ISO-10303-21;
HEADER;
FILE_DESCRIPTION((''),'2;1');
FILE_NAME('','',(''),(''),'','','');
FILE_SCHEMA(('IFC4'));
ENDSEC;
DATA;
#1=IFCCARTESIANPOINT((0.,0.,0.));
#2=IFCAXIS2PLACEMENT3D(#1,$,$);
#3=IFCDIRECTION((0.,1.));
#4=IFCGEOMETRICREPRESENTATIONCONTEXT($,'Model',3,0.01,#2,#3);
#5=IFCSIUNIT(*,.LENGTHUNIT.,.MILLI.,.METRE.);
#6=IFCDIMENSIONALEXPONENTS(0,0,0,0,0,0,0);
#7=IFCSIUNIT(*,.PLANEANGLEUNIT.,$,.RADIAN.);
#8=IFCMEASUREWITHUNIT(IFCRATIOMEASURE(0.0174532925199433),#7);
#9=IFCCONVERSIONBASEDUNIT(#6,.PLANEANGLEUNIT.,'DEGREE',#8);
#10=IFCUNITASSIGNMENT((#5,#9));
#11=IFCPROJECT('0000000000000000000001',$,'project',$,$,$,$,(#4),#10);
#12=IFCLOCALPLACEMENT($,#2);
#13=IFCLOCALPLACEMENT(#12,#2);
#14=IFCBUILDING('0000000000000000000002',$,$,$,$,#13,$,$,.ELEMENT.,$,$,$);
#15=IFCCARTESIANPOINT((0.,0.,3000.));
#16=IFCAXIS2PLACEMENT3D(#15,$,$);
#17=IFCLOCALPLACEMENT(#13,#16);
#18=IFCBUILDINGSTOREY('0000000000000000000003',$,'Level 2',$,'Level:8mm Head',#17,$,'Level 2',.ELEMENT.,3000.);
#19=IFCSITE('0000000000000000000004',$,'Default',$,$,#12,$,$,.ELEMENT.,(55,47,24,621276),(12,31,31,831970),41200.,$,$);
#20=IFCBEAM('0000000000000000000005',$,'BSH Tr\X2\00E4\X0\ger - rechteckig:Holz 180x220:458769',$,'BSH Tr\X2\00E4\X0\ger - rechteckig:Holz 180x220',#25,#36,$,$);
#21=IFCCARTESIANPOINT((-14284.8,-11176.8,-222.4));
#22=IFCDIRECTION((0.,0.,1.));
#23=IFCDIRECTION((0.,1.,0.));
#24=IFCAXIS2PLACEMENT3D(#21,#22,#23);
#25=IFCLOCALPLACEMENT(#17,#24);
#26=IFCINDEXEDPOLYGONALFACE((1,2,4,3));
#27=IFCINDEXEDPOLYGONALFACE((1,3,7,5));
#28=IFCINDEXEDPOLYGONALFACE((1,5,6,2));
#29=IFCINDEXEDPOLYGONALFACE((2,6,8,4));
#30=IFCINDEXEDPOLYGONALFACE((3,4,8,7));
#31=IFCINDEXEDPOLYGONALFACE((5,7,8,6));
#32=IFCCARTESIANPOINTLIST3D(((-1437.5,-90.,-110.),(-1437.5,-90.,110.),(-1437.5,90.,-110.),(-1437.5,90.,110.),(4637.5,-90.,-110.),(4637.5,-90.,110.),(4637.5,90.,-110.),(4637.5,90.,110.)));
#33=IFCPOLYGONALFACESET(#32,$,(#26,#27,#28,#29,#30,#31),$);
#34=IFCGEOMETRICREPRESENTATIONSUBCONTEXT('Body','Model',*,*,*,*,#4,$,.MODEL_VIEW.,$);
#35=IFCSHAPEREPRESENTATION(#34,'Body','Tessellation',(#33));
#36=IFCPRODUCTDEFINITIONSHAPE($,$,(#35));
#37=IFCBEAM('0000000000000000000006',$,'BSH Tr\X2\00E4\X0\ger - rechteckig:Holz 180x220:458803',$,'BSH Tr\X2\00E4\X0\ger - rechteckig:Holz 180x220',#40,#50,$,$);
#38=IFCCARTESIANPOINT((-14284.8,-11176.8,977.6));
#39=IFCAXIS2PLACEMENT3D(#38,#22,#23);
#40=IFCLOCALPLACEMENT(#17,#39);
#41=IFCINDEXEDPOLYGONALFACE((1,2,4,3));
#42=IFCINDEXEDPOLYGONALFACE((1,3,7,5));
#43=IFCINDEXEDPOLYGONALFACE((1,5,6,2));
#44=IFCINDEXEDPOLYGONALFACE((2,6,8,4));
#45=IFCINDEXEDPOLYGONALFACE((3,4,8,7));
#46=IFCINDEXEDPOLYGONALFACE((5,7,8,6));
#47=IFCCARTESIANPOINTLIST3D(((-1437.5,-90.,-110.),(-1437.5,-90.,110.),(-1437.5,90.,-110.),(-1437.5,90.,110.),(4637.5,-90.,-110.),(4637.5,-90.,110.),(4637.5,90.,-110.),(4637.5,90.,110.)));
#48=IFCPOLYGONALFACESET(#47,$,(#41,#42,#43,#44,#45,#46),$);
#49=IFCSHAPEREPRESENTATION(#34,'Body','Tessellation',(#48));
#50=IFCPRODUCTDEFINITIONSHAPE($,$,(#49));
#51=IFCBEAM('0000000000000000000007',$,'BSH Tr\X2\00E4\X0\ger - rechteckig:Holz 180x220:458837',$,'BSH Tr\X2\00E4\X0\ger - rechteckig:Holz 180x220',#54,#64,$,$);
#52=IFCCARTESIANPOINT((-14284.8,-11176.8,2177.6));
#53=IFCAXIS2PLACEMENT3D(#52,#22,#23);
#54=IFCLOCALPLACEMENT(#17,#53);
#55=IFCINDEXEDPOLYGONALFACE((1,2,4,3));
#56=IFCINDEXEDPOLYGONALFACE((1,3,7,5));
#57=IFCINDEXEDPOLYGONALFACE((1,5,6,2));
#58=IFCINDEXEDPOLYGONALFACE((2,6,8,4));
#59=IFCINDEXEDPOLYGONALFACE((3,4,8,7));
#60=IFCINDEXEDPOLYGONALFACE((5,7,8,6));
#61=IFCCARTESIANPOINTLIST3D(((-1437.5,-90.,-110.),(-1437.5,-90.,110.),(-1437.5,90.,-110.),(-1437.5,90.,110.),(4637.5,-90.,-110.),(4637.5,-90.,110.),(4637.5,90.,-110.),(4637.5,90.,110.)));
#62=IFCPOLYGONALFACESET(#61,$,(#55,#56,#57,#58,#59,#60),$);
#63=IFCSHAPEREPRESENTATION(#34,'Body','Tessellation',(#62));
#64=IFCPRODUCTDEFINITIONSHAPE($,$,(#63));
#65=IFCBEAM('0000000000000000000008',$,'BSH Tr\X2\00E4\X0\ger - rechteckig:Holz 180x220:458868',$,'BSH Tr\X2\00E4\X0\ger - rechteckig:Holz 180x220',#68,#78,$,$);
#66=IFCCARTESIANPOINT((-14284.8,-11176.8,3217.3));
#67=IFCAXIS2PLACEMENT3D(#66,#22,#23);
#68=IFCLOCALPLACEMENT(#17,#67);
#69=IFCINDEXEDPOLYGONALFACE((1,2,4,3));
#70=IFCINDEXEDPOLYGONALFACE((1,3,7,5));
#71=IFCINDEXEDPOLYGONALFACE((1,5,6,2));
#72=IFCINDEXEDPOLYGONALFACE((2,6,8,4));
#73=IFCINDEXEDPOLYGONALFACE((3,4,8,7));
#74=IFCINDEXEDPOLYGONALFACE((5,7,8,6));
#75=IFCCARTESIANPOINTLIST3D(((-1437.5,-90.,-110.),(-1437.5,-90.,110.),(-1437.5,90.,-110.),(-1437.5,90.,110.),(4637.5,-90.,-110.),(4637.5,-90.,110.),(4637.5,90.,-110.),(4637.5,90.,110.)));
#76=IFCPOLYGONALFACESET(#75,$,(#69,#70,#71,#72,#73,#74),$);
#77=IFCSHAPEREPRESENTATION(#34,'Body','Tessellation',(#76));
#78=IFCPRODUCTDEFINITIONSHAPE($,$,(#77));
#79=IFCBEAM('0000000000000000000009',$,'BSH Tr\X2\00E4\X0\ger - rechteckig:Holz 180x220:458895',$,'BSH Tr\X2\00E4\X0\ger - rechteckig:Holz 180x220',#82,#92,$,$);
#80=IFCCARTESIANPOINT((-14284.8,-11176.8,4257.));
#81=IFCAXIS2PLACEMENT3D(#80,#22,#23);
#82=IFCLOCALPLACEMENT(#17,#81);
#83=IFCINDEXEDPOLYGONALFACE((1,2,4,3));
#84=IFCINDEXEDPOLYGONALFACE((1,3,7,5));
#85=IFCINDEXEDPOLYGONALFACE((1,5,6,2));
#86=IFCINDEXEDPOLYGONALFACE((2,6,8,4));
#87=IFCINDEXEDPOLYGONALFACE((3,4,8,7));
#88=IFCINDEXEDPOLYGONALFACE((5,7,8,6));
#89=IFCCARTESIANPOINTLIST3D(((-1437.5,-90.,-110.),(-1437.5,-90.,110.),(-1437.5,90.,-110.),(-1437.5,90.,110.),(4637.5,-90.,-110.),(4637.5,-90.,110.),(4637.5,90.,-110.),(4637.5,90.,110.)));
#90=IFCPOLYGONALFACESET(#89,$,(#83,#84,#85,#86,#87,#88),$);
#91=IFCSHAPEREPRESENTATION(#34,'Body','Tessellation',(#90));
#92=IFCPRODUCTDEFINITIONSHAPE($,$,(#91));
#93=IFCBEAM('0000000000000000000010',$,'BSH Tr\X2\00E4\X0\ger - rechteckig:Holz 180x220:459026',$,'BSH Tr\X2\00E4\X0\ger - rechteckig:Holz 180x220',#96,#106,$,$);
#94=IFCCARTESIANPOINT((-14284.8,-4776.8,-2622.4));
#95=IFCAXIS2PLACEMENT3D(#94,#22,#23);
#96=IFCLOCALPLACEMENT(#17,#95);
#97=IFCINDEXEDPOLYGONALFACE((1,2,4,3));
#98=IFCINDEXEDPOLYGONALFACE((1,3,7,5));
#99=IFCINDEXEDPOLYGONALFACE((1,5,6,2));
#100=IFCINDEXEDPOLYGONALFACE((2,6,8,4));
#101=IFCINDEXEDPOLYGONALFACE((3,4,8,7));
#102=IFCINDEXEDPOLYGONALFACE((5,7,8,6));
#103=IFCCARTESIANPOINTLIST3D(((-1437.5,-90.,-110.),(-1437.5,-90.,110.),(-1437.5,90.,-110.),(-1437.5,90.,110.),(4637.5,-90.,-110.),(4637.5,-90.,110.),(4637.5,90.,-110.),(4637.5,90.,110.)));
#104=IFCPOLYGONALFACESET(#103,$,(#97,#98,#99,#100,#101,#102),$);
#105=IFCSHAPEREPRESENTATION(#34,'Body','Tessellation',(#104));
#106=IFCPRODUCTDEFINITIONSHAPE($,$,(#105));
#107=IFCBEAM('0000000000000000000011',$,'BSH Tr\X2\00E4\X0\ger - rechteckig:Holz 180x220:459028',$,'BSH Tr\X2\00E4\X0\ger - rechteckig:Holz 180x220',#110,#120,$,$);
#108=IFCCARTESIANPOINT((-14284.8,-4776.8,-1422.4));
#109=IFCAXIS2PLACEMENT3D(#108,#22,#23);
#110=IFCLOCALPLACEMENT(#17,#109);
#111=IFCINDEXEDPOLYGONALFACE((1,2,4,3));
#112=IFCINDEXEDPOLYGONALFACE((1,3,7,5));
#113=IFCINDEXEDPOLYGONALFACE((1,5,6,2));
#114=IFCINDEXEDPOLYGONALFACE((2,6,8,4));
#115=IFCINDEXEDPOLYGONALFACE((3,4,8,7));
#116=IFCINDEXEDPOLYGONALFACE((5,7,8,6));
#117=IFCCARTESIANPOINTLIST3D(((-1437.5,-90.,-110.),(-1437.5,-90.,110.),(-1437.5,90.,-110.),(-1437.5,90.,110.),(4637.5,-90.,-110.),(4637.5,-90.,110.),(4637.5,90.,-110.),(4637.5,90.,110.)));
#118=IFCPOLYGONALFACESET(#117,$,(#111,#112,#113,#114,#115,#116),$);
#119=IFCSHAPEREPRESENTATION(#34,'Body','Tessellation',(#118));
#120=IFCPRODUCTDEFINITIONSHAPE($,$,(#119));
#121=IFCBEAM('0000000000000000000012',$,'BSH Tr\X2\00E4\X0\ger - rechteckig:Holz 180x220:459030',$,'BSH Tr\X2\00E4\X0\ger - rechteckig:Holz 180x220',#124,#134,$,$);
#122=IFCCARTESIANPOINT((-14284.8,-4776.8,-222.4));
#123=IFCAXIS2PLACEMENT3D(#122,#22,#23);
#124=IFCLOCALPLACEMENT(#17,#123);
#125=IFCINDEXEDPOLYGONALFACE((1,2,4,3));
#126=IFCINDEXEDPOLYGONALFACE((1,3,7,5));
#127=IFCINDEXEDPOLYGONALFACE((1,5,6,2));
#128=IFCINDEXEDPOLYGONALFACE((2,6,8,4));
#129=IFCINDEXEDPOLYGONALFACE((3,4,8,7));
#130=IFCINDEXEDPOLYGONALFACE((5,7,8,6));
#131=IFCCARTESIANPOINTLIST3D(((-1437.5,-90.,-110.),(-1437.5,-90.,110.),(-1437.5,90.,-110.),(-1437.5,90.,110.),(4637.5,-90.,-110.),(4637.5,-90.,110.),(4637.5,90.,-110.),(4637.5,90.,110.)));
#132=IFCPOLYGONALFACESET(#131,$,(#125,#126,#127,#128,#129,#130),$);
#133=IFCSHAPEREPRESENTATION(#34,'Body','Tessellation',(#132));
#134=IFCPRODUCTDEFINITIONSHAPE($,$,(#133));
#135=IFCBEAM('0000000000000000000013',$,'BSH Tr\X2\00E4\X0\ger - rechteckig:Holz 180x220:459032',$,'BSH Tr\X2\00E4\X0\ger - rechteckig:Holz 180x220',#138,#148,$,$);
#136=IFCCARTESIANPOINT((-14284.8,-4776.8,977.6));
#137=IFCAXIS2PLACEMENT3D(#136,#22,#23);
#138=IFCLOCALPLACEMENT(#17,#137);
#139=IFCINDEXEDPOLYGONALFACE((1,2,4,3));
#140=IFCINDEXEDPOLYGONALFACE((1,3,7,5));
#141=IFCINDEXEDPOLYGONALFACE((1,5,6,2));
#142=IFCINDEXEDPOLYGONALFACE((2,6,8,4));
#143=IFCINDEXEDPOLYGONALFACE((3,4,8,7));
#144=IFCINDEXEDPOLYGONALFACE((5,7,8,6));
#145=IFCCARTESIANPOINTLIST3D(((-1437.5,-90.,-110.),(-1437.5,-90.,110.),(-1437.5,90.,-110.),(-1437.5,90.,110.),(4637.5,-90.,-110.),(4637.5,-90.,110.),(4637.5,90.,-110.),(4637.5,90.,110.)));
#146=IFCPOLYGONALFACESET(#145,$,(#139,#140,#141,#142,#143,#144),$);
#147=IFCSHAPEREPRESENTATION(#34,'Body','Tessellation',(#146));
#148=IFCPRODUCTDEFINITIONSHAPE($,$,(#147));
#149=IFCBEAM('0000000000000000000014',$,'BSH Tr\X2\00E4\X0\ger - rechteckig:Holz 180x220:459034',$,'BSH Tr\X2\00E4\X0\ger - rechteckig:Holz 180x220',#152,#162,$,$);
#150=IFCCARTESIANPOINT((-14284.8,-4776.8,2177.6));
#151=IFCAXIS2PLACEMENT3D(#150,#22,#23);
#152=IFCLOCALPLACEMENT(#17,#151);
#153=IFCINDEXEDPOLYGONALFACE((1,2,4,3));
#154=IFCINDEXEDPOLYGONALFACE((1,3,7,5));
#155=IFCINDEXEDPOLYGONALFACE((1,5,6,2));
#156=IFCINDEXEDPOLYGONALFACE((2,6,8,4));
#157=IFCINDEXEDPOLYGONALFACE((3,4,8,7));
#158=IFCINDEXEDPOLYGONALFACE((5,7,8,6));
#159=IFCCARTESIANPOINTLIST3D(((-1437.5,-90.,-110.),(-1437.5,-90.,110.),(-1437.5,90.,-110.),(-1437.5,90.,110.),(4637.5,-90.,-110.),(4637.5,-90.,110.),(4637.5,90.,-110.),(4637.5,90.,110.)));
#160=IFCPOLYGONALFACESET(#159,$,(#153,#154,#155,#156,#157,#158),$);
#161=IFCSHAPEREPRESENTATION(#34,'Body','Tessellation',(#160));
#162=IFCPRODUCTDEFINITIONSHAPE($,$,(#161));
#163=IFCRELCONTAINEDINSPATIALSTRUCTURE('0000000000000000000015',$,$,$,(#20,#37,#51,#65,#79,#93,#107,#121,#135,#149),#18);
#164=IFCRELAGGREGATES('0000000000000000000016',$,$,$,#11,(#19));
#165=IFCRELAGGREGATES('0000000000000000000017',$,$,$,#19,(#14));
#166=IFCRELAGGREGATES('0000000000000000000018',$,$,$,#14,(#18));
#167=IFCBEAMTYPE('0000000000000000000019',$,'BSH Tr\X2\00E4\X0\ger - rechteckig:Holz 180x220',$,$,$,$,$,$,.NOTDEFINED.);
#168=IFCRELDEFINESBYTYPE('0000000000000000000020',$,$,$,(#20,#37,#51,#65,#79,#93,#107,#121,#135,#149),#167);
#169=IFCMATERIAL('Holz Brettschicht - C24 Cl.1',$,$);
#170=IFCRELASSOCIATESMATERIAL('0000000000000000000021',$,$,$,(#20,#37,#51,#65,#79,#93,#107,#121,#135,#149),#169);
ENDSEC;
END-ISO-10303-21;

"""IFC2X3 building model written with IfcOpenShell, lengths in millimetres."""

from ifc_helpers import new_model, entity, si_unit, converted_unit, direction, frame, frame_2d, origin, place, context, subcontext, project, spatial, rectangle, extrude, material, type_object, element, save


model = new_model("IFC2X3")

# Units and contexts
model_context = context("Model", 3, precision=0.01, world=origin(), true_north=direction((0.0, 1.0)))
body_context = subcontext(model_context, "Body", "Model", "MODEL_VIEW")
ifc_project = project(units=[si_unit("LENGTHUNIT", "METRE", prefix="MILLI"), converted_unit("PLANEANGLEUNIT", "DEGREE", entity("IfcRatioMeasure", 0.0174532925199433), si_unit("PLANEANGLEUNIT", "RADIAN"), dimensions=[0, 0, 0, 0, 0, 0, 0])], contexts=[model_context])

# Site, building, storey
site_placement = place(None, origin())
site = spatial("IfcSite", under=ifc_project, at=site_placement, Name="Default", CompositionType="ELEMENT", RefLatitude=(55, 47, 24, 621276), RefLongitude=(12, 31, 31, 831970), RefElevation=41200.0)
building_placement = place(site_placement, origin())
building = spatial("IfcBuilding", under=site, at=building_placement, CompositionType="ELEMENT")
storey_placement = place(building_placement, frame((0.0, 0.0, 3000.0)))
storey = spatial("IfcBuildingStorey", under=building, at=storey_placement, Name="Level 2", ObjectType="Level:8mm Head", LongName="Level 2", CompositionType="ELEMENT", Elevation=3000.0)

# Beams
ifc_material = material(Name="Holz Brettschicht - C24 Cl.1")
beam_type_1 = type_object("IfcBeamType", Name="BSH Träger - rechteckig:Holz 180x220", PredefinedType="NOTDEFINED")
for number, where, z_axis, x_axis, name in (
    (1, (-14284.8, -11176.8, -222.4), (0.0, 0.0, 1.0), (0.0, 1.0, 0.0), "BSH Träger - rechteckig:Holz 180x220:458769"),
    (2, (-14284.8, -11176.8, 977.6), (0.0, 0.0, 1.0), (0.0, 1.0, 0.0), "BSH Träger - rechteckig:Holz 180x220:458803"),
):
    element("IfcBeam", number, at=place(storey_placement, frame(where, z_axis=z_axis, x_axis=x_axis)), inside=storey, type_object=beam_type_1, material=ifc_material, Name=name, ObjectType="BSH Träger - rechteckig:Holz 180x220", context=body_context, shape_type="SweptSolid", body=[
        extrude(rectangle(XDim=220.0, YDim=180.0, at=frame_2d((0.0, 0.0), x_axis=(1.0, 0.0))), frame((-1437.5, 0.0, 0.0), z_axis=(1.0, 0.0, 0.0), x_axis=(0.0, 0.0, -1.0)), (0.0, 0.0, 1.0), 6075.0),
    ])
for number, where, z_axis, x_axis, name in (
    (3, (-14284.8, -11176.8, 2177.6), (0.0, 0.0, 1.0), (0.0, 1.0, 0.0), "BSH Träger - rechteckig:Holz 180x220:458837"),
    (4, (-14284.8, -11176.8, 3217.3), (0.0, 0.0, 1.0), (0.0, 1.0, 0.0), "BSH Träger - rechteckig:Holz 180x220:458868"),
):
    element("IfcBeam", number, at=place(storey_placement, frame(where, z_axis=z_axis, x_axis=x_axis)), inside=storey, type_object=beam_type_1, material=ifc_material, Name=name, ObjectType="BSH Träger - rechteckig:Holz 180x220", context=body_context, shape_type="SweptSolid", body=[
        extrude(rectangle(XDim=220.0, YDim=180.0, at=frame_2d((0.0, 0.0), x_axis=(1.0, 0.0))), frame((-1437.5, 0.0, 0.0), z_axis=(1.0, 0.0, 0.0), x_axis=(0.0, 0.0, -1.0)), (0.0, 0.0, 1.0), 6075.0),
    ])
beam_1_placement = place(storey_placement, frame((-14284.8, -11176.8, 4257.0), z_axis=(0.0, 0.0, 1.0), x_axis=(0.0, 1.0, 0.0)))
element("IfcBeam", 5, at=beam_1_placement, inside=storey, type_object=beam_type_1, material=ifc_material, Name="BSH Träger - rechteckig:Holz 180x220:458895", ObjectType="BSH Träger - rechteckig:Holz 180x220", context=body_context, shape_type="SweptSolid", body=[
    extrude(rectangle(XDim=220.0, YDim=180.0, at=frame_2d((0.0, 0.0), x_axis=(1.0, 0.0))), frame((-1437.5, 0.0, 0.0), z_axis=(1.0, 0.0, 0.0), x_axis=(0.0, 0.0, -1.0)), (0.0, 0.0, 1.0), 6075.0),
])
beam_2_placement = place(storey_placement, frame((-14284.8, -4776.8, -2622.4), z_axis=(0.0, 0.0, 1.0), x_axis=(0.0, 1.0, 0.0)))
element("IfcBeam", 6, at=beam_2_placement, inside=storey, type_object=beam_type_1, material=ifc_material, Name="BSH Träger - rechteckig:Holz 180x220:459026", ObjectType="BSH Träger - rechteckig:Holz 180x220", context=body_context, shape_type="SweptSolid", body=[
    extrude(rectangle(XDim=220.0, YDim=180.0, at=frame_2d((0.0, 0.0), x_axis=(1.0, 0.0))), frame((-1437.5, 0.0, 0.0), z_axis=(1.0, 0.0, 0.0), x_axis=(0.0, 0.0, -1.0)), (0.0, 0.0, 1.0), 6075.0),
])
beam_3_placement = place(storey_placement, frame((-14284.8, -4776.8, -1422.4), z_axis=(0.0, 0.0, 1.0), x_axis=(0.0, 1.0, 0.0)))
element("IfcBeam", 7, at=beam_3_placement, inside=storey, type_object=beam_type_1, material=ifc_material, Name="BSH Träger - rechteckig:Holz 180x220:459028", ObjectType="BSH Träger - rechteckig:Holz 180x220", context=body_context, shape_type="SweptSolid", body=[
    extrude(rectangle(XDim=220.0, YDim=180.0, at=frame_2d((0.0, 0.0), x_axis=(1.0, 0.0))), frame((-1437.5, 0.0, 0.0), z_axis=(1.0, 0.0, 0.0), x_axis=(0.0, 0.0, -1.0)), (0.0, 0.0, 1.0), 6075.0),
])
for number, where, z_axis, x_axis, name in (
    (8, (-14284.8, -4776.8, -222.4), (0.0, 0.0, 1.0), (0.0, 1.0, 0.0), "BSH Träger - rechteckig:Holz 180x220:459030"),
    (9, (-14284.8, -4776.8, 977.6), (0.0, 0.0, 1.0), (0.0, 1.0, 0.0), "BSH Träger - rechteckig:Holz 180x220:459032"),
):
    element("IfcBeam", number, at=place(storey_placement, frame(where, z_axis=z_axis, x_axis=x_axis)), inside=storey, type_object=beam_type_1, material=ifc_material, Name=name, ObjectType="BSH Träger - rechteckig:Holz 180x220", context=body_context, shape_type="SweptSolid", body=[
        extrude(rectangle(XDim=220.0, YDim=180.0, at=frame_2d((0.0, 0.0), x_axis=(1.0, 0.0))), frame((-1437.5, 0.0, 0.0), z_axis=(1.0, 0.0, 0.0), x_axis=(0.0, 0.0, -1.0)), (0.0, 0.0, 1.0), 6075.0),
    ])
beam_4_placement = place(storey_placement, frame((-14284.8, -4776.8, 2177.6), z_axis=(0.0, 0.0, 1.0), x_axis=(0.0, 1.0, 0.0)))
element("IfcBeam", 10, at=beam_4_placement, inside=storey, type_object=beam_type_1, material=ifc_material, Name="BSH Träger - rechteckig:Holz 180x220:459034", ObjectType="BSH Träger - rechteckig:Holz 180x220", context=body_context, shape_type="SweptSolid", body=[
    extrude(rectangle(XDim=220.0, YDim=180.0, at=frame_2d((0.0, 0.0), x_axis=(1.0, 0.0))), frame((-1437.5, 0.0, 0.0), z_axis=(1.0, 0.0, 0.0), x_axis=(0.0, 0.0, -1.0)), (0.0, 0.0, 1.0), 6075.0),
])

save(model, "model.ifc")
